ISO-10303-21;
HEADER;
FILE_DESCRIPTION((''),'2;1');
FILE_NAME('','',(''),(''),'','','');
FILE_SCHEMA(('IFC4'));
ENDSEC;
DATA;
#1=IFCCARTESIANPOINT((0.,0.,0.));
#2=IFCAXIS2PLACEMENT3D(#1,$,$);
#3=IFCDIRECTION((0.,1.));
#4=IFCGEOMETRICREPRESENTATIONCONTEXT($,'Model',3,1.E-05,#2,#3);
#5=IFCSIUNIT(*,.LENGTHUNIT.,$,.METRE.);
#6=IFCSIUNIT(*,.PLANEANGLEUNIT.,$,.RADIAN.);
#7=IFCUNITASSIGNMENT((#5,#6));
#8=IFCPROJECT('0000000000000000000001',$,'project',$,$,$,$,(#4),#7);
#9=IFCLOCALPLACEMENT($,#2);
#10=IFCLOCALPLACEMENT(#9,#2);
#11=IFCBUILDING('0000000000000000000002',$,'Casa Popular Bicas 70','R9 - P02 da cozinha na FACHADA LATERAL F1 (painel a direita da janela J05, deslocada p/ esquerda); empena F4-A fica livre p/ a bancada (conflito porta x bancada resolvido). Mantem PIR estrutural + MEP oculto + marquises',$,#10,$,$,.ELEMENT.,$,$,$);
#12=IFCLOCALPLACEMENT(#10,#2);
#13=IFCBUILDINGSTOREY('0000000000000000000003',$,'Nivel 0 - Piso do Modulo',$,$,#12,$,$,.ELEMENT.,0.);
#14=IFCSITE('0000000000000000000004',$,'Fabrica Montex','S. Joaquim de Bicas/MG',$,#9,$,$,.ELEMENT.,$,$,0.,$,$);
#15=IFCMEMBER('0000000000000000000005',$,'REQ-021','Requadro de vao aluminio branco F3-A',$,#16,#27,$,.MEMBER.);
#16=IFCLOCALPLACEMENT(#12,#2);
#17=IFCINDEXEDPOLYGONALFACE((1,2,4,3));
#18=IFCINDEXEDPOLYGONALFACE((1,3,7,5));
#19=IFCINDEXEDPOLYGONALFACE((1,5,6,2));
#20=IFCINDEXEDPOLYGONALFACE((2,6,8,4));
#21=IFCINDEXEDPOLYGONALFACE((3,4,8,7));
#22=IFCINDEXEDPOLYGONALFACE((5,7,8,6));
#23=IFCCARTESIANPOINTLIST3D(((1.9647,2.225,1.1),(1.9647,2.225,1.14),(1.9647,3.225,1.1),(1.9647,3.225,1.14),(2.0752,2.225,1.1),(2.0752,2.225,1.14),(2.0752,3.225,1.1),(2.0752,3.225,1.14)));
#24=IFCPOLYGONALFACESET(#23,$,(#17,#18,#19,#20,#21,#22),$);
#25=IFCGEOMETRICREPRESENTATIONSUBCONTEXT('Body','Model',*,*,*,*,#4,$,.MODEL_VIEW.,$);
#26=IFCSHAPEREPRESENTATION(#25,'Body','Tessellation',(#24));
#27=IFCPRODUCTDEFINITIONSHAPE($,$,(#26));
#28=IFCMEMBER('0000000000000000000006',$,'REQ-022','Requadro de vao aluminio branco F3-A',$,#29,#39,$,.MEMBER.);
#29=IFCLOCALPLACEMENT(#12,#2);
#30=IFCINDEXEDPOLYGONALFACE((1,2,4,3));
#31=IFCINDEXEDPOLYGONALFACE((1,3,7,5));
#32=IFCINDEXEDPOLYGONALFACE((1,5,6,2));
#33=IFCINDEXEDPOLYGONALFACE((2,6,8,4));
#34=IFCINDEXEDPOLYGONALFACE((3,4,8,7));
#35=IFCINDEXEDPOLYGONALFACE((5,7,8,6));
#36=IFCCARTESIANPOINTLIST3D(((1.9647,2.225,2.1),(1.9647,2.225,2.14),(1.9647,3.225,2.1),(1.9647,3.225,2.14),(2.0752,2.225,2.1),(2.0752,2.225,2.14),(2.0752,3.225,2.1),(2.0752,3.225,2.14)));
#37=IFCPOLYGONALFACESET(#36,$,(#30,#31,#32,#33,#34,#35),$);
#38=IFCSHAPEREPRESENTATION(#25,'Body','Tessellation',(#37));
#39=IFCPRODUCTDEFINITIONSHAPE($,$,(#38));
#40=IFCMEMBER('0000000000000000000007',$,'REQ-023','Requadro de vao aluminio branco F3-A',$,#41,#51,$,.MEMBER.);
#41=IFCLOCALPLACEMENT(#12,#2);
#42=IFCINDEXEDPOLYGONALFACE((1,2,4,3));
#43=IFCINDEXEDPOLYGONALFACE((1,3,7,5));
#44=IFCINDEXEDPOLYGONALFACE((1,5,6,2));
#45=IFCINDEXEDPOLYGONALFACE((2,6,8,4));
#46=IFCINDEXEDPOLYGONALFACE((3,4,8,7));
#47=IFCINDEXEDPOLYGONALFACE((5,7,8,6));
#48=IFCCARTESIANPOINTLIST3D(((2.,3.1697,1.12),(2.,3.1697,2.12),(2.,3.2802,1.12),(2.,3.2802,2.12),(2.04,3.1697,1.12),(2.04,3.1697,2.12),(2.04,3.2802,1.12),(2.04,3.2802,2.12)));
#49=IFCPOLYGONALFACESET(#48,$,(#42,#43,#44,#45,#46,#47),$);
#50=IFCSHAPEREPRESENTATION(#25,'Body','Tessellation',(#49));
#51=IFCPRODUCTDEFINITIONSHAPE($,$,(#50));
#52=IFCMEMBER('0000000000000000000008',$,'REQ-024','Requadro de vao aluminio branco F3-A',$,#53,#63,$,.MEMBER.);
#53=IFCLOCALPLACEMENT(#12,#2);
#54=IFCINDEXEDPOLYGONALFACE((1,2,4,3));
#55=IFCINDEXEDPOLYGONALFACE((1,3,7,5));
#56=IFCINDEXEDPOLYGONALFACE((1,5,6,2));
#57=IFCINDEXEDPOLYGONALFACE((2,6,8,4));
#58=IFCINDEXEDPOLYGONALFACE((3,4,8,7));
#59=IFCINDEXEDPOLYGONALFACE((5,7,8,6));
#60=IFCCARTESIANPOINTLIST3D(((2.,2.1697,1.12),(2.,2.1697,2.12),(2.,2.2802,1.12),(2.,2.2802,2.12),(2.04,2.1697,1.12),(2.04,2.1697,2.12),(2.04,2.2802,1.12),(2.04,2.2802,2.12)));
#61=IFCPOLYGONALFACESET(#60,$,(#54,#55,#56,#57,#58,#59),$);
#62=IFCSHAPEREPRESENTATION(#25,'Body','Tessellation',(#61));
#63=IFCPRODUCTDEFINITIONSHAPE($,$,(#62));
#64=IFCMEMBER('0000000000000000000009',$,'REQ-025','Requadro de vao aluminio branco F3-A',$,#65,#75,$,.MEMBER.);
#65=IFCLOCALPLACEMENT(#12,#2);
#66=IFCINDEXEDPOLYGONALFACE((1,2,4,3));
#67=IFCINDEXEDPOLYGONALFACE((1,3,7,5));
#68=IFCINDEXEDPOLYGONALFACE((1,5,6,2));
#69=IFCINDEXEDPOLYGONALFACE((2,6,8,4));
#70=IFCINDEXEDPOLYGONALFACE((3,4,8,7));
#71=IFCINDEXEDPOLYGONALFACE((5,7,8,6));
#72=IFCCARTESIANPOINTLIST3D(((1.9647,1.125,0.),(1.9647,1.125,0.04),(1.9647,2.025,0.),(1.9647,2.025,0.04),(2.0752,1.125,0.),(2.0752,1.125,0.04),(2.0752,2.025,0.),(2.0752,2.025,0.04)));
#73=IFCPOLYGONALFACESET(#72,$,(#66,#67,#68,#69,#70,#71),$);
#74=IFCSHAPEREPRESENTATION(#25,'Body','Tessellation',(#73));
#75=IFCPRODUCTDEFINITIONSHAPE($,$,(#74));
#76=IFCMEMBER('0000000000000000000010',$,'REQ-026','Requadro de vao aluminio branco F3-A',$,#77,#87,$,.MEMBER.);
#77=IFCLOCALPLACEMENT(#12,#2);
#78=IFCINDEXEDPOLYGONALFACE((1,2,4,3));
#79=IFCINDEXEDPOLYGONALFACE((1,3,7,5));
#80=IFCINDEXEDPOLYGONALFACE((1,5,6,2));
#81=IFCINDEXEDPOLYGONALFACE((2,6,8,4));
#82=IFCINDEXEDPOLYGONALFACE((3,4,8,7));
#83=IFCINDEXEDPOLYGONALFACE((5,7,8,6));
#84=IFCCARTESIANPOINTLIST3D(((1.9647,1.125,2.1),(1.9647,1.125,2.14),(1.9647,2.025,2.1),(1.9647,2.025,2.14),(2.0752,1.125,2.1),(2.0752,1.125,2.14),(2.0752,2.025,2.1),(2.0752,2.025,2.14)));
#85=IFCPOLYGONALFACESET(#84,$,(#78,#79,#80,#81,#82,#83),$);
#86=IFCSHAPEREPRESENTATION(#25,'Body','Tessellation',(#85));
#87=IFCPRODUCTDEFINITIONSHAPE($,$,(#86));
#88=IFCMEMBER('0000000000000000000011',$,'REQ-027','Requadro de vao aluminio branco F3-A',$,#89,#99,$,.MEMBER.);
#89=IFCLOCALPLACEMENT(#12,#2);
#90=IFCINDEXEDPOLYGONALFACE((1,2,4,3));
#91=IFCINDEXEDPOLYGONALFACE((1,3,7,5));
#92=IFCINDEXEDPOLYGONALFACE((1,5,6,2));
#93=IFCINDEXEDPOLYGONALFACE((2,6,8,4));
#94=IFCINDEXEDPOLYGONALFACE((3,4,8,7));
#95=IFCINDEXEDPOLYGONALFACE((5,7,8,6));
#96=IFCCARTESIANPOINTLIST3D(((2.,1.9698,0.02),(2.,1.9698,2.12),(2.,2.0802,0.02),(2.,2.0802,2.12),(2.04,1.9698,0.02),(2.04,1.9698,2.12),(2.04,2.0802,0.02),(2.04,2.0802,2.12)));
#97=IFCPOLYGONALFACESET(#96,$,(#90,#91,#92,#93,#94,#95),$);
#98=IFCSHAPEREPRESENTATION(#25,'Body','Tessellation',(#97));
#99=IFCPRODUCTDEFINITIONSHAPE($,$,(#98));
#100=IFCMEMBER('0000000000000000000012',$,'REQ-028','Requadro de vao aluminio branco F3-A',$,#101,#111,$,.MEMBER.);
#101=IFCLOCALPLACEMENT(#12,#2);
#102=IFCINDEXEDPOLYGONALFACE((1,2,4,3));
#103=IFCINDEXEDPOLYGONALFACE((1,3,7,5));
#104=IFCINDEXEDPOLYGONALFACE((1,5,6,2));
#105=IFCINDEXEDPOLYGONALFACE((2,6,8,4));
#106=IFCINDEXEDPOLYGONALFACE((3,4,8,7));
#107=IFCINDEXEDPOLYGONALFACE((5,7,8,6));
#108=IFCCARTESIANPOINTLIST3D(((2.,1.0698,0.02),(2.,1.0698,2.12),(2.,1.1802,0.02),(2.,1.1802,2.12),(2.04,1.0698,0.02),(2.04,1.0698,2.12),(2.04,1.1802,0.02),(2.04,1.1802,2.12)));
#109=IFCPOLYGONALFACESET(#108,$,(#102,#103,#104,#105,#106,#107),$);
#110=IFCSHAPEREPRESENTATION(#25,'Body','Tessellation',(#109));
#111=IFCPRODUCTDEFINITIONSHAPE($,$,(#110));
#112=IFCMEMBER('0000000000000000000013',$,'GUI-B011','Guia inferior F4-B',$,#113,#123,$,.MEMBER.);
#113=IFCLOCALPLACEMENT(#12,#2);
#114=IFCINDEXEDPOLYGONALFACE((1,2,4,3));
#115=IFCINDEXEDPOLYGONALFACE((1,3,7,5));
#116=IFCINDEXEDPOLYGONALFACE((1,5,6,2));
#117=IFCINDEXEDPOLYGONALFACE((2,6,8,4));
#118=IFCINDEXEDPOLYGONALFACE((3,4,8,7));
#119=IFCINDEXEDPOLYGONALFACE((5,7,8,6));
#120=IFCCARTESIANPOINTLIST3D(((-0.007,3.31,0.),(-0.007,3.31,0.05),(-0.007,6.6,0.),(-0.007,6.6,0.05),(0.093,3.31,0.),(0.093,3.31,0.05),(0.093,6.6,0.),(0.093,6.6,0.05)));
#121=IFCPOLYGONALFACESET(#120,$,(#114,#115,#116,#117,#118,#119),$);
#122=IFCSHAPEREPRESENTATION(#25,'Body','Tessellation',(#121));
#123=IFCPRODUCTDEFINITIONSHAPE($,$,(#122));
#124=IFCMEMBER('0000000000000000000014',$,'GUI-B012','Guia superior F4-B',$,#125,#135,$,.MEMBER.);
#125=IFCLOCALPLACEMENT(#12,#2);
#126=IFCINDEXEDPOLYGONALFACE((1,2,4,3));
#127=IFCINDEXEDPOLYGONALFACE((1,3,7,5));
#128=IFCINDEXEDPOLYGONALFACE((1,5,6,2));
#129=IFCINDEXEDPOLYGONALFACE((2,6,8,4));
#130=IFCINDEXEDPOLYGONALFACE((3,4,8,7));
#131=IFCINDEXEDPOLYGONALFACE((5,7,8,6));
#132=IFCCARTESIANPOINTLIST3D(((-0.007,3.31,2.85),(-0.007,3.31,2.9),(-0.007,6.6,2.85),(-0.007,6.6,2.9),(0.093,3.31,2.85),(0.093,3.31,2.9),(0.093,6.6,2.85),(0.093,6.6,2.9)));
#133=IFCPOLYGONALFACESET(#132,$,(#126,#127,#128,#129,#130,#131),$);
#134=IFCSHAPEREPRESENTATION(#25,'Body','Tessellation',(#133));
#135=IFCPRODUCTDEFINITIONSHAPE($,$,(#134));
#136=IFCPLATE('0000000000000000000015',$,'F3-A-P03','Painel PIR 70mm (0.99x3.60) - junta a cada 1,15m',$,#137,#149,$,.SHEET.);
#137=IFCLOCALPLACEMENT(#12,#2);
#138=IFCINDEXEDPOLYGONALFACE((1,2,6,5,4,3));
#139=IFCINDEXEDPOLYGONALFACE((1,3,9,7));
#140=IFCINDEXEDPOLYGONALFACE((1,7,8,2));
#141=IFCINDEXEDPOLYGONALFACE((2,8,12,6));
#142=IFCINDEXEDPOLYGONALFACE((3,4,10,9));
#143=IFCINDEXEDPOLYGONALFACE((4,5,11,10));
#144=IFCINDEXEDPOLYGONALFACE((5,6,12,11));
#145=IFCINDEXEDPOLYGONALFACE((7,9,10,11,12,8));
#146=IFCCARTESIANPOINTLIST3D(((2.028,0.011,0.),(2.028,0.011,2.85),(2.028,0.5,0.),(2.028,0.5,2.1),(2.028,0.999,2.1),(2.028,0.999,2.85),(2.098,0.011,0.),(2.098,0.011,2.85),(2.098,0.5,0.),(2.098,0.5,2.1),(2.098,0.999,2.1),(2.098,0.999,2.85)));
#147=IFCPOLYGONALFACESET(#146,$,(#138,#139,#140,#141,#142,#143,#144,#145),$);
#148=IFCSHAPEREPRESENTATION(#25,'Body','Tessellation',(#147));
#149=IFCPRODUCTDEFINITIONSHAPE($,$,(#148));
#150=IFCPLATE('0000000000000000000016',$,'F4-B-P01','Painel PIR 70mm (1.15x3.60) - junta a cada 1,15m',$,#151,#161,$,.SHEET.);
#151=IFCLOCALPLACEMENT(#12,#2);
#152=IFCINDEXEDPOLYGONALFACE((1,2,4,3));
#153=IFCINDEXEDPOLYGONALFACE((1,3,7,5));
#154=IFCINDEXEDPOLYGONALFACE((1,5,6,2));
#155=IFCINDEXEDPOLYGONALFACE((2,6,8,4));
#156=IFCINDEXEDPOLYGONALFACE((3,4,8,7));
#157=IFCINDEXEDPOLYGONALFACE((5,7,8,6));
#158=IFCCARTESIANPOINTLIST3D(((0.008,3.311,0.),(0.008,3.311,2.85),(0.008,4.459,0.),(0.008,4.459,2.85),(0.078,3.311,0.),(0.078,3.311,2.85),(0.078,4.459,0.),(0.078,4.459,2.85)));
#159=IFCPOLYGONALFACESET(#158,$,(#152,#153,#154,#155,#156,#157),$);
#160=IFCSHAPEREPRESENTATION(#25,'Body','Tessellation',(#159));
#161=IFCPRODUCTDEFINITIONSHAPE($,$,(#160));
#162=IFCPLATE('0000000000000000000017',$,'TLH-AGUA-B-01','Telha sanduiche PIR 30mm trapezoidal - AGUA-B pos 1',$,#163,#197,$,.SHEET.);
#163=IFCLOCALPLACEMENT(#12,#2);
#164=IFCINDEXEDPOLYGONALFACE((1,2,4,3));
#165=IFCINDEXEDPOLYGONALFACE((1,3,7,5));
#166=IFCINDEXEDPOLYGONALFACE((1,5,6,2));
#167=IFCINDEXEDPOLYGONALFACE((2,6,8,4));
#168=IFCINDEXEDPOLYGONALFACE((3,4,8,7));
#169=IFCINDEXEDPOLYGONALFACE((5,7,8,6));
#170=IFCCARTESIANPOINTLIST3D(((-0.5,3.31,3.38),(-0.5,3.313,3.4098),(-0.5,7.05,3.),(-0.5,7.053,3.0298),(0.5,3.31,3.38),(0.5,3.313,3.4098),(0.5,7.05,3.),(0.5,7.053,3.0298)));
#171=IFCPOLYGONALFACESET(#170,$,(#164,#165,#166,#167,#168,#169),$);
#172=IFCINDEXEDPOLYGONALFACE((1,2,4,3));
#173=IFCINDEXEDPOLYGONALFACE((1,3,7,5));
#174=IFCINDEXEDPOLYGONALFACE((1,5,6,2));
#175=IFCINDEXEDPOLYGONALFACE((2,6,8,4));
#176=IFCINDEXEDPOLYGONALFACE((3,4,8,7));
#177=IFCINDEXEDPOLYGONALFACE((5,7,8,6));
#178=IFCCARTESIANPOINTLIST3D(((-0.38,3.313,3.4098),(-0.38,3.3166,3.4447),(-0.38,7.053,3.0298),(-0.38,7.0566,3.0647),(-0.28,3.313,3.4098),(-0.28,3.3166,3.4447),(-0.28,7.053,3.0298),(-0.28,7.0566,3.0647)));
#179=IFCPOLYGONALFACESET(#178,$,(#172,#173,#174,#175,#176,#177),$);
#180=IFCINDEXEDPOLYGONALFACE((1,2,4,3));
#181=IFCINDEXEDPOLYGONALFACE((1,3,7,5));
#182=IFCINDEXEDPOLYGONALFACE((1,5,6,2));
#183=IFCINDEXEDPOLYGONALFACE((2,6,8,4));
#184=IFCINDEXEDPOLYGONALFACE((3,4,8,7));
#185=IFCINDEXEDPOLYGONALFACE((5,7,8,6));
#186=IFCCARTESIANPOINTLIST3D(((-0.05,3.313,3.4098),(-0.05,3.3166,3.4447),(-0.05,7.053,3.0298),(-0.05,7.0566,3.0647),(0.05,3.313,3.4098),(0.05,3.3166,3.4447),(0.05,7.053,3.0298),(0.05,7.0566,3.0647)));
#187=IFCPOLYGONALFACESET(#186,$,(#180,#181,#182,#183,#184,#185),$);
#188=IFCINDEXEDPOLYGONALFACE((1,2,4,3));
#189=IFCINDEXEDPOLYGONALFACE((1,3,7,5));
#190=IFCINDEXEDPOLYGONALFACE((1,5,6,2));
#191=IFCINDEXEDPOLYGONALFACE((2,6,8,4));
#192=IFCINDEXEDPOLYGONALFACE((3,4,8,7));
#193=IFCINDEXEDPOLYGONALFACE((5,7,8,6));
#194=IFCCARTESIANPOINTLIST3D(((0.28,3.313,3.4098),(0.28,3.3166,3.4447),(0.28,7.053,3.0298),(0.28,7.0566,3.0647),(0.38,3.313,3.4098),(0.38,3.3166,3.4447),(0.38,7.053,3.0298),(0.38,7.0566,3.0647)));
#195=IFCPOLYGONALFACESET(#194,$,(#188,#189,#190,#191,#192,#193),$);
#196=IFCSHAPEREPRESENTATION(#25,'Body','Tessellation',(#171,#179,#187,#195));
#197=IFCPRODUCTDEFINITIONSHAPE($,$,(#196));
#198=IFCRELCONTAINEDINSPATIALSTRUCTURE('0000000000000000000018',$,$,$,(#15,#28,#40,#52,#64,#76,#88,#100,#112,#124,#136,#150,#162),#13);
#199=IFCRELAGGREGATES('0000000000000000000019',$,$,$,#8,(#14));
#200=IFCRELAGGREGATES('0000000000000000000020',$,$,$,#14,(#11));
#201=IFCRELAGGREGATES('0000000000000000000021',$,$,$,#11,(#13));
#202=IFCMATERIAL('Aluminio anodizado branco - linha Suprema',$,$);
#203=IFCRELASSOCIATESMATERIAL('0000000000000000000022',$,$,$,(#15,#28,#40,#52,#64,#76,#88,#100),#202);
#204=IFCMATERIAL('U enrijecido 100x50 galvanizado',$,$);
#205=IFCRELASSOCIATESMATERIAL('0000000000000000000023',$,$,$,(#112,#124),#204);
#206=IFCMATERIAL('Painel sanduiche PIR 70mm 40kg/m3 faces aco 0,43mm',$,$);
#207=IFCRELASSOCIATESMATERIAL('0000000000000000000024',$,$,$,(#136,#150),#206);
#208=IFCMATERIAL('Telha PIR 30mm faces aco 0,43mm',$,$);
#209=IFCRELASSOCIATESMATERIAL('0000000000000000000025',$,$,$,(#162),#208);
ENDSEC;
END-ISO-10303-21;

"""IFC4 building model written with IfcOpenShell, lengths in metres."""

from ifc_helpers import new_model, si_unit, direction, frame, frame_2d, origin, origin_2d, place, context, subcontext, project, spatial, rectangle, extrude, material, element, save


model = new_model("IFC4")

# Units and contexts
model_context = context("Model", 3, precision=1e-05, world=origin(), true_north=direction((0.0, 1.0)))
body_context = subcontext(model_context, "Body", "Model", "MODEL_VIEW")
ifc_project = project(units=[si_unit("LENGTHUNIT", "METRE"), si_unit("PLANEANGLEUNIT", "RADIAN")], contexts=[model_context])

# Site, building, storey
site_placement = place(None, origin())
site = spatial("IfcSite", under=ifc_project, at=site_placement, Name="Fabrica Montex", Description="S. Joaquim de Bicas/MG", CompositionType="ELEMENT", RefElevation=0.0)
building_placement = place(site_placement, origin())
building = spatial("IfcBuilding", under=site, at=building_placement, Name="Casa Popular Bicas 70", Description="R9 - P02 da cozinha na FACHADA LATERAL F1 (painel a direita da janela J05, deslocada p/ esquerda); empena F4-A fica livre p/ a bancada (conflito porta x bancada resolvido). Mantem PIR estrutural + MEP oculto + marquises", CompositionType="ELEMENT")
storey_placement = place(building_placement, origin())
storey = spatial("IfcBuildingStorey", under=building, at=storey_placement, Name="Nivel 0 - Piso do Modulo", CompositionType="ELEMENT", Elevation=0.0)

# Members
ifc_material_1 = material(Name="Aluminio anodizado branco - linha Suprema")
for number, where, z_axis, x_axis, name in (
    (1, (2.02, 3.225, 1.12), (0.0, -1.0, 0.0), (0.0, 0.0, 1.0), "REQ-021"),
    (2, (2.02, 3.225, 2.12), (0.0, -1.0, 0.0), (0.0, 0.0, 1.0), "REQ-022"),
    (3, (2.02, 3.225, 1.12), (0.0, 0.0, 1.0), (-1.0, 0.0, 0.0), "REQ-023"),
    (4, (2.02, 2.225, 1.12), (0.0, 0.0, 1.0), (-1.0, 0.0, 0.0), "REQ-024"),
):
    element("IfcMember", number, at=place(None, frame(where, z_axis=z_axis, x_axis=x_axis)), inside=storey, material=ifc_material_1, Name=name, Description="Requadro de vao aluminio branco F3-A", PredefinedType="MEMBER", context=body_context, shape_type="SweptSolid", body=[
        extrude(rectangle(XDim=0.04, YDim=0.1105, at=origin_2d()), origin(), (0.0, 0.0, 1.0), 1.0),
    ])
for number, where, z_axis, x_axis, name in (
    (5, (2.02, 2.025, 0.02), (0.0, -1.0, 0.0), (0.0, 0.0, 1.0), "REQ-025"),
    (6, (2.02, 2.025, 2.12), (0.0, -1.0, 0.0), (0.0, 0.0, 1.0), "REQ-026"),
):
    element("IfcMember", number, at=place(None, frame(where, z_axis=z_axis, x_axis=x_axis)), inside=storey, material=ifc_material_1, Name=name, Description="Requadro de vao aluminio branco F3-A", PredefinedType="MEMBER", context=body_context, shape_type="SweptSolid", body=[
        extrude(rectangle(XDim=0.04, YDim=0.1105, at=origin_2d()), origin(), (0.0, 0.0, 1.0), 0.9),
    ])
for number, where, z_axis, x_axis, name in (
    (7, (2.02, 2.025, 0.02), (0.0, 0.0, 1.0), (-1.0, 0.0, 0.0), "REQ-027"),
    (8, (2.02, 1.125, 0.02), (0.0, 0.0, 1.0), (-1.0, 0.0, 0.0), "REQ-028"),
):
    element("IfcMember", number, at=place(None, frame(where, z_axis=z_axis, x_axis=x_axis)), inside=storey, material=ifc_material_1, Name=name, Description="Requadro de vao aluminio branco F3-A", PredefinedType="MEMBER", context=body_context, shape_type="SweptSolid", body=[
        extrude(rectangle(XDim=0.04, YDim=0.1105, at=origin_2d()), origin(), (0.0, 0.0, 1.0), 2.1),
    ])
ifc_material_2 = material(Name="U enrijecido 100x50 galvanizado")
for number, where, z_axis, x_axis, name, description in (
    (9, (0.043, 3.31, 0.025), (0.0, 1.0, 0.0), (0.0, 0.0, 1.0), "GUI-B011", "Guia inferior F4-B"),
    (10, (0.043, 3.31, 2.875), (0.0, 1.0, 0.0), (0.0, 0.0, 1.0), "GUI-B012", "Guia superior F4-B"),
):
    element("IfcMember", number, at=place(storey_placement, frame(where, z_axis=z_axis, x_axis=x_axis)), inside=storey, material=ifc_material_2, Name=name, Description=description, PredefinedType="MEMBER", context=body_context, shape_type="SweptSolid", body=[
        extrude(rectangle(XDim=0.05, YDim=0.1, at=origin_2d()), origin(), (0.0, 0.0, 1.0), 3.29),
    ])

# Plate, opening
ifc_material_3 = material(Name="Painel sanduiche PIR 70mm 40kg/m3 faces aco 0,43mm")
plate_1_placement = place(None, frame((2.063, 0.999, 0.0), z_axis=(0.0, 0.0, 1.0), x_axis=(0.0, -1.0, 0.0)))
plate_1 = element("IfcPlate", 11, at=plate_1_placement, inside=storey, material=ifc_material_3, Name="F3-A-P03", Description="Painel PIR 70mm (0.99x3.60) - junta a cada 1,15m", PredefinedType="SHEET", context=body_context, shape_type="SweptSolid", body=[
    extrude(rectangle(XDim=0.988, YDim=0.07, at=frame_2d((0.494, 0.0))), origin(), (0.0, 0.0, 1.0), 2.85),
])
opening_1_placement = place(None, frame((2.063, 0.75, 0.0), z_axis=(0.0, 0.0, 1.0), x_axis=(-1.0, 0.0, 0.0)))
element("IfcOpeningElement", 12, at=opening_1_placement, cuts=plate_1, PredefinedType="OPENING", context=body_context, shape_type="SweptSolid", body=[
    extrude(rectangle(XDim=0.1, YDim=0.5, at=origin_2d()), origin(), (0.0, 0.0, 1.0), 2.1),
])

# Plates
plate_2_placement = place(storey_placement, frame((0.043, 3.311, 0.0), x_axis=(0.0, 1.0, 0.0)))
element("IfcPlate", 13, at=plate_2_placement, inside=storey, material=ifc_material_3, Name="F4-B-P01", Description="Painel PIR 70mm (1.15x3.60) - junta a cada 1,15m", PredefinedType="SHEET", context=body_context, shape_type="SweptSolid", body=[
    extrude(rectangle(XDim=1.148, YDim=0.07, at=frame_2d((0.574, 0.0))), origin(), (0.0, 0.0, 1.0), 2.85),
])
ifc_material_4 = material(Name="Telha PIR 30mm faces aco 0,43mm")
for number, where, z_axis, x_axis, name in (
    (14, (-0.5, 3.31, 3.38), (0.0, 0.101084, 0.994878), (1.0, 0.0, 0.0), "TLH-AGUA-B-01"),
):
    element("IfcPlate", number, at=place(storey_placement, frame(where, z_axis=z_axis, x_axis=x_axis)), inside=storey, material=ifc_material_4, Name=name, Description="Telha sanduiche PIR 30mm trapezoidal - AGUA-B pos 1", PredefinedType="SHEET", context=body_context, shape_type="SweptSolid", body=[
        extrude(rectangle(XDim=1.0, YDim=3.7593, at=frame_2d((0.5, 1.8796))), origin(), (0.0, 0.0, 1.0), 0.03),
        extrude(rectangle(XDim=0.1, YDim=3.7593, at=frame_2d((0.17, 1.8796))), frame((0.0, 0.0, 0.03)), (0.0, 0.0, 1.0), 0.035),
        extrude(rectangle(XDim=0.1, YDim=3.7593, at=frame_2d((0.5, 1.8796))), frame((0.0, 0.0, 0.03)), (0.0, 0.0, 1.0), 0.035),
        extrude(rectangle(XDim=0.1, YDim=3.7593, at=frame_2d((0.83, 1.8796))), frame((0.0, 0.0, 0.03)), (0.0, 0.0, 1.0), 0.035),
    ])

save(model, "model.ifc")
